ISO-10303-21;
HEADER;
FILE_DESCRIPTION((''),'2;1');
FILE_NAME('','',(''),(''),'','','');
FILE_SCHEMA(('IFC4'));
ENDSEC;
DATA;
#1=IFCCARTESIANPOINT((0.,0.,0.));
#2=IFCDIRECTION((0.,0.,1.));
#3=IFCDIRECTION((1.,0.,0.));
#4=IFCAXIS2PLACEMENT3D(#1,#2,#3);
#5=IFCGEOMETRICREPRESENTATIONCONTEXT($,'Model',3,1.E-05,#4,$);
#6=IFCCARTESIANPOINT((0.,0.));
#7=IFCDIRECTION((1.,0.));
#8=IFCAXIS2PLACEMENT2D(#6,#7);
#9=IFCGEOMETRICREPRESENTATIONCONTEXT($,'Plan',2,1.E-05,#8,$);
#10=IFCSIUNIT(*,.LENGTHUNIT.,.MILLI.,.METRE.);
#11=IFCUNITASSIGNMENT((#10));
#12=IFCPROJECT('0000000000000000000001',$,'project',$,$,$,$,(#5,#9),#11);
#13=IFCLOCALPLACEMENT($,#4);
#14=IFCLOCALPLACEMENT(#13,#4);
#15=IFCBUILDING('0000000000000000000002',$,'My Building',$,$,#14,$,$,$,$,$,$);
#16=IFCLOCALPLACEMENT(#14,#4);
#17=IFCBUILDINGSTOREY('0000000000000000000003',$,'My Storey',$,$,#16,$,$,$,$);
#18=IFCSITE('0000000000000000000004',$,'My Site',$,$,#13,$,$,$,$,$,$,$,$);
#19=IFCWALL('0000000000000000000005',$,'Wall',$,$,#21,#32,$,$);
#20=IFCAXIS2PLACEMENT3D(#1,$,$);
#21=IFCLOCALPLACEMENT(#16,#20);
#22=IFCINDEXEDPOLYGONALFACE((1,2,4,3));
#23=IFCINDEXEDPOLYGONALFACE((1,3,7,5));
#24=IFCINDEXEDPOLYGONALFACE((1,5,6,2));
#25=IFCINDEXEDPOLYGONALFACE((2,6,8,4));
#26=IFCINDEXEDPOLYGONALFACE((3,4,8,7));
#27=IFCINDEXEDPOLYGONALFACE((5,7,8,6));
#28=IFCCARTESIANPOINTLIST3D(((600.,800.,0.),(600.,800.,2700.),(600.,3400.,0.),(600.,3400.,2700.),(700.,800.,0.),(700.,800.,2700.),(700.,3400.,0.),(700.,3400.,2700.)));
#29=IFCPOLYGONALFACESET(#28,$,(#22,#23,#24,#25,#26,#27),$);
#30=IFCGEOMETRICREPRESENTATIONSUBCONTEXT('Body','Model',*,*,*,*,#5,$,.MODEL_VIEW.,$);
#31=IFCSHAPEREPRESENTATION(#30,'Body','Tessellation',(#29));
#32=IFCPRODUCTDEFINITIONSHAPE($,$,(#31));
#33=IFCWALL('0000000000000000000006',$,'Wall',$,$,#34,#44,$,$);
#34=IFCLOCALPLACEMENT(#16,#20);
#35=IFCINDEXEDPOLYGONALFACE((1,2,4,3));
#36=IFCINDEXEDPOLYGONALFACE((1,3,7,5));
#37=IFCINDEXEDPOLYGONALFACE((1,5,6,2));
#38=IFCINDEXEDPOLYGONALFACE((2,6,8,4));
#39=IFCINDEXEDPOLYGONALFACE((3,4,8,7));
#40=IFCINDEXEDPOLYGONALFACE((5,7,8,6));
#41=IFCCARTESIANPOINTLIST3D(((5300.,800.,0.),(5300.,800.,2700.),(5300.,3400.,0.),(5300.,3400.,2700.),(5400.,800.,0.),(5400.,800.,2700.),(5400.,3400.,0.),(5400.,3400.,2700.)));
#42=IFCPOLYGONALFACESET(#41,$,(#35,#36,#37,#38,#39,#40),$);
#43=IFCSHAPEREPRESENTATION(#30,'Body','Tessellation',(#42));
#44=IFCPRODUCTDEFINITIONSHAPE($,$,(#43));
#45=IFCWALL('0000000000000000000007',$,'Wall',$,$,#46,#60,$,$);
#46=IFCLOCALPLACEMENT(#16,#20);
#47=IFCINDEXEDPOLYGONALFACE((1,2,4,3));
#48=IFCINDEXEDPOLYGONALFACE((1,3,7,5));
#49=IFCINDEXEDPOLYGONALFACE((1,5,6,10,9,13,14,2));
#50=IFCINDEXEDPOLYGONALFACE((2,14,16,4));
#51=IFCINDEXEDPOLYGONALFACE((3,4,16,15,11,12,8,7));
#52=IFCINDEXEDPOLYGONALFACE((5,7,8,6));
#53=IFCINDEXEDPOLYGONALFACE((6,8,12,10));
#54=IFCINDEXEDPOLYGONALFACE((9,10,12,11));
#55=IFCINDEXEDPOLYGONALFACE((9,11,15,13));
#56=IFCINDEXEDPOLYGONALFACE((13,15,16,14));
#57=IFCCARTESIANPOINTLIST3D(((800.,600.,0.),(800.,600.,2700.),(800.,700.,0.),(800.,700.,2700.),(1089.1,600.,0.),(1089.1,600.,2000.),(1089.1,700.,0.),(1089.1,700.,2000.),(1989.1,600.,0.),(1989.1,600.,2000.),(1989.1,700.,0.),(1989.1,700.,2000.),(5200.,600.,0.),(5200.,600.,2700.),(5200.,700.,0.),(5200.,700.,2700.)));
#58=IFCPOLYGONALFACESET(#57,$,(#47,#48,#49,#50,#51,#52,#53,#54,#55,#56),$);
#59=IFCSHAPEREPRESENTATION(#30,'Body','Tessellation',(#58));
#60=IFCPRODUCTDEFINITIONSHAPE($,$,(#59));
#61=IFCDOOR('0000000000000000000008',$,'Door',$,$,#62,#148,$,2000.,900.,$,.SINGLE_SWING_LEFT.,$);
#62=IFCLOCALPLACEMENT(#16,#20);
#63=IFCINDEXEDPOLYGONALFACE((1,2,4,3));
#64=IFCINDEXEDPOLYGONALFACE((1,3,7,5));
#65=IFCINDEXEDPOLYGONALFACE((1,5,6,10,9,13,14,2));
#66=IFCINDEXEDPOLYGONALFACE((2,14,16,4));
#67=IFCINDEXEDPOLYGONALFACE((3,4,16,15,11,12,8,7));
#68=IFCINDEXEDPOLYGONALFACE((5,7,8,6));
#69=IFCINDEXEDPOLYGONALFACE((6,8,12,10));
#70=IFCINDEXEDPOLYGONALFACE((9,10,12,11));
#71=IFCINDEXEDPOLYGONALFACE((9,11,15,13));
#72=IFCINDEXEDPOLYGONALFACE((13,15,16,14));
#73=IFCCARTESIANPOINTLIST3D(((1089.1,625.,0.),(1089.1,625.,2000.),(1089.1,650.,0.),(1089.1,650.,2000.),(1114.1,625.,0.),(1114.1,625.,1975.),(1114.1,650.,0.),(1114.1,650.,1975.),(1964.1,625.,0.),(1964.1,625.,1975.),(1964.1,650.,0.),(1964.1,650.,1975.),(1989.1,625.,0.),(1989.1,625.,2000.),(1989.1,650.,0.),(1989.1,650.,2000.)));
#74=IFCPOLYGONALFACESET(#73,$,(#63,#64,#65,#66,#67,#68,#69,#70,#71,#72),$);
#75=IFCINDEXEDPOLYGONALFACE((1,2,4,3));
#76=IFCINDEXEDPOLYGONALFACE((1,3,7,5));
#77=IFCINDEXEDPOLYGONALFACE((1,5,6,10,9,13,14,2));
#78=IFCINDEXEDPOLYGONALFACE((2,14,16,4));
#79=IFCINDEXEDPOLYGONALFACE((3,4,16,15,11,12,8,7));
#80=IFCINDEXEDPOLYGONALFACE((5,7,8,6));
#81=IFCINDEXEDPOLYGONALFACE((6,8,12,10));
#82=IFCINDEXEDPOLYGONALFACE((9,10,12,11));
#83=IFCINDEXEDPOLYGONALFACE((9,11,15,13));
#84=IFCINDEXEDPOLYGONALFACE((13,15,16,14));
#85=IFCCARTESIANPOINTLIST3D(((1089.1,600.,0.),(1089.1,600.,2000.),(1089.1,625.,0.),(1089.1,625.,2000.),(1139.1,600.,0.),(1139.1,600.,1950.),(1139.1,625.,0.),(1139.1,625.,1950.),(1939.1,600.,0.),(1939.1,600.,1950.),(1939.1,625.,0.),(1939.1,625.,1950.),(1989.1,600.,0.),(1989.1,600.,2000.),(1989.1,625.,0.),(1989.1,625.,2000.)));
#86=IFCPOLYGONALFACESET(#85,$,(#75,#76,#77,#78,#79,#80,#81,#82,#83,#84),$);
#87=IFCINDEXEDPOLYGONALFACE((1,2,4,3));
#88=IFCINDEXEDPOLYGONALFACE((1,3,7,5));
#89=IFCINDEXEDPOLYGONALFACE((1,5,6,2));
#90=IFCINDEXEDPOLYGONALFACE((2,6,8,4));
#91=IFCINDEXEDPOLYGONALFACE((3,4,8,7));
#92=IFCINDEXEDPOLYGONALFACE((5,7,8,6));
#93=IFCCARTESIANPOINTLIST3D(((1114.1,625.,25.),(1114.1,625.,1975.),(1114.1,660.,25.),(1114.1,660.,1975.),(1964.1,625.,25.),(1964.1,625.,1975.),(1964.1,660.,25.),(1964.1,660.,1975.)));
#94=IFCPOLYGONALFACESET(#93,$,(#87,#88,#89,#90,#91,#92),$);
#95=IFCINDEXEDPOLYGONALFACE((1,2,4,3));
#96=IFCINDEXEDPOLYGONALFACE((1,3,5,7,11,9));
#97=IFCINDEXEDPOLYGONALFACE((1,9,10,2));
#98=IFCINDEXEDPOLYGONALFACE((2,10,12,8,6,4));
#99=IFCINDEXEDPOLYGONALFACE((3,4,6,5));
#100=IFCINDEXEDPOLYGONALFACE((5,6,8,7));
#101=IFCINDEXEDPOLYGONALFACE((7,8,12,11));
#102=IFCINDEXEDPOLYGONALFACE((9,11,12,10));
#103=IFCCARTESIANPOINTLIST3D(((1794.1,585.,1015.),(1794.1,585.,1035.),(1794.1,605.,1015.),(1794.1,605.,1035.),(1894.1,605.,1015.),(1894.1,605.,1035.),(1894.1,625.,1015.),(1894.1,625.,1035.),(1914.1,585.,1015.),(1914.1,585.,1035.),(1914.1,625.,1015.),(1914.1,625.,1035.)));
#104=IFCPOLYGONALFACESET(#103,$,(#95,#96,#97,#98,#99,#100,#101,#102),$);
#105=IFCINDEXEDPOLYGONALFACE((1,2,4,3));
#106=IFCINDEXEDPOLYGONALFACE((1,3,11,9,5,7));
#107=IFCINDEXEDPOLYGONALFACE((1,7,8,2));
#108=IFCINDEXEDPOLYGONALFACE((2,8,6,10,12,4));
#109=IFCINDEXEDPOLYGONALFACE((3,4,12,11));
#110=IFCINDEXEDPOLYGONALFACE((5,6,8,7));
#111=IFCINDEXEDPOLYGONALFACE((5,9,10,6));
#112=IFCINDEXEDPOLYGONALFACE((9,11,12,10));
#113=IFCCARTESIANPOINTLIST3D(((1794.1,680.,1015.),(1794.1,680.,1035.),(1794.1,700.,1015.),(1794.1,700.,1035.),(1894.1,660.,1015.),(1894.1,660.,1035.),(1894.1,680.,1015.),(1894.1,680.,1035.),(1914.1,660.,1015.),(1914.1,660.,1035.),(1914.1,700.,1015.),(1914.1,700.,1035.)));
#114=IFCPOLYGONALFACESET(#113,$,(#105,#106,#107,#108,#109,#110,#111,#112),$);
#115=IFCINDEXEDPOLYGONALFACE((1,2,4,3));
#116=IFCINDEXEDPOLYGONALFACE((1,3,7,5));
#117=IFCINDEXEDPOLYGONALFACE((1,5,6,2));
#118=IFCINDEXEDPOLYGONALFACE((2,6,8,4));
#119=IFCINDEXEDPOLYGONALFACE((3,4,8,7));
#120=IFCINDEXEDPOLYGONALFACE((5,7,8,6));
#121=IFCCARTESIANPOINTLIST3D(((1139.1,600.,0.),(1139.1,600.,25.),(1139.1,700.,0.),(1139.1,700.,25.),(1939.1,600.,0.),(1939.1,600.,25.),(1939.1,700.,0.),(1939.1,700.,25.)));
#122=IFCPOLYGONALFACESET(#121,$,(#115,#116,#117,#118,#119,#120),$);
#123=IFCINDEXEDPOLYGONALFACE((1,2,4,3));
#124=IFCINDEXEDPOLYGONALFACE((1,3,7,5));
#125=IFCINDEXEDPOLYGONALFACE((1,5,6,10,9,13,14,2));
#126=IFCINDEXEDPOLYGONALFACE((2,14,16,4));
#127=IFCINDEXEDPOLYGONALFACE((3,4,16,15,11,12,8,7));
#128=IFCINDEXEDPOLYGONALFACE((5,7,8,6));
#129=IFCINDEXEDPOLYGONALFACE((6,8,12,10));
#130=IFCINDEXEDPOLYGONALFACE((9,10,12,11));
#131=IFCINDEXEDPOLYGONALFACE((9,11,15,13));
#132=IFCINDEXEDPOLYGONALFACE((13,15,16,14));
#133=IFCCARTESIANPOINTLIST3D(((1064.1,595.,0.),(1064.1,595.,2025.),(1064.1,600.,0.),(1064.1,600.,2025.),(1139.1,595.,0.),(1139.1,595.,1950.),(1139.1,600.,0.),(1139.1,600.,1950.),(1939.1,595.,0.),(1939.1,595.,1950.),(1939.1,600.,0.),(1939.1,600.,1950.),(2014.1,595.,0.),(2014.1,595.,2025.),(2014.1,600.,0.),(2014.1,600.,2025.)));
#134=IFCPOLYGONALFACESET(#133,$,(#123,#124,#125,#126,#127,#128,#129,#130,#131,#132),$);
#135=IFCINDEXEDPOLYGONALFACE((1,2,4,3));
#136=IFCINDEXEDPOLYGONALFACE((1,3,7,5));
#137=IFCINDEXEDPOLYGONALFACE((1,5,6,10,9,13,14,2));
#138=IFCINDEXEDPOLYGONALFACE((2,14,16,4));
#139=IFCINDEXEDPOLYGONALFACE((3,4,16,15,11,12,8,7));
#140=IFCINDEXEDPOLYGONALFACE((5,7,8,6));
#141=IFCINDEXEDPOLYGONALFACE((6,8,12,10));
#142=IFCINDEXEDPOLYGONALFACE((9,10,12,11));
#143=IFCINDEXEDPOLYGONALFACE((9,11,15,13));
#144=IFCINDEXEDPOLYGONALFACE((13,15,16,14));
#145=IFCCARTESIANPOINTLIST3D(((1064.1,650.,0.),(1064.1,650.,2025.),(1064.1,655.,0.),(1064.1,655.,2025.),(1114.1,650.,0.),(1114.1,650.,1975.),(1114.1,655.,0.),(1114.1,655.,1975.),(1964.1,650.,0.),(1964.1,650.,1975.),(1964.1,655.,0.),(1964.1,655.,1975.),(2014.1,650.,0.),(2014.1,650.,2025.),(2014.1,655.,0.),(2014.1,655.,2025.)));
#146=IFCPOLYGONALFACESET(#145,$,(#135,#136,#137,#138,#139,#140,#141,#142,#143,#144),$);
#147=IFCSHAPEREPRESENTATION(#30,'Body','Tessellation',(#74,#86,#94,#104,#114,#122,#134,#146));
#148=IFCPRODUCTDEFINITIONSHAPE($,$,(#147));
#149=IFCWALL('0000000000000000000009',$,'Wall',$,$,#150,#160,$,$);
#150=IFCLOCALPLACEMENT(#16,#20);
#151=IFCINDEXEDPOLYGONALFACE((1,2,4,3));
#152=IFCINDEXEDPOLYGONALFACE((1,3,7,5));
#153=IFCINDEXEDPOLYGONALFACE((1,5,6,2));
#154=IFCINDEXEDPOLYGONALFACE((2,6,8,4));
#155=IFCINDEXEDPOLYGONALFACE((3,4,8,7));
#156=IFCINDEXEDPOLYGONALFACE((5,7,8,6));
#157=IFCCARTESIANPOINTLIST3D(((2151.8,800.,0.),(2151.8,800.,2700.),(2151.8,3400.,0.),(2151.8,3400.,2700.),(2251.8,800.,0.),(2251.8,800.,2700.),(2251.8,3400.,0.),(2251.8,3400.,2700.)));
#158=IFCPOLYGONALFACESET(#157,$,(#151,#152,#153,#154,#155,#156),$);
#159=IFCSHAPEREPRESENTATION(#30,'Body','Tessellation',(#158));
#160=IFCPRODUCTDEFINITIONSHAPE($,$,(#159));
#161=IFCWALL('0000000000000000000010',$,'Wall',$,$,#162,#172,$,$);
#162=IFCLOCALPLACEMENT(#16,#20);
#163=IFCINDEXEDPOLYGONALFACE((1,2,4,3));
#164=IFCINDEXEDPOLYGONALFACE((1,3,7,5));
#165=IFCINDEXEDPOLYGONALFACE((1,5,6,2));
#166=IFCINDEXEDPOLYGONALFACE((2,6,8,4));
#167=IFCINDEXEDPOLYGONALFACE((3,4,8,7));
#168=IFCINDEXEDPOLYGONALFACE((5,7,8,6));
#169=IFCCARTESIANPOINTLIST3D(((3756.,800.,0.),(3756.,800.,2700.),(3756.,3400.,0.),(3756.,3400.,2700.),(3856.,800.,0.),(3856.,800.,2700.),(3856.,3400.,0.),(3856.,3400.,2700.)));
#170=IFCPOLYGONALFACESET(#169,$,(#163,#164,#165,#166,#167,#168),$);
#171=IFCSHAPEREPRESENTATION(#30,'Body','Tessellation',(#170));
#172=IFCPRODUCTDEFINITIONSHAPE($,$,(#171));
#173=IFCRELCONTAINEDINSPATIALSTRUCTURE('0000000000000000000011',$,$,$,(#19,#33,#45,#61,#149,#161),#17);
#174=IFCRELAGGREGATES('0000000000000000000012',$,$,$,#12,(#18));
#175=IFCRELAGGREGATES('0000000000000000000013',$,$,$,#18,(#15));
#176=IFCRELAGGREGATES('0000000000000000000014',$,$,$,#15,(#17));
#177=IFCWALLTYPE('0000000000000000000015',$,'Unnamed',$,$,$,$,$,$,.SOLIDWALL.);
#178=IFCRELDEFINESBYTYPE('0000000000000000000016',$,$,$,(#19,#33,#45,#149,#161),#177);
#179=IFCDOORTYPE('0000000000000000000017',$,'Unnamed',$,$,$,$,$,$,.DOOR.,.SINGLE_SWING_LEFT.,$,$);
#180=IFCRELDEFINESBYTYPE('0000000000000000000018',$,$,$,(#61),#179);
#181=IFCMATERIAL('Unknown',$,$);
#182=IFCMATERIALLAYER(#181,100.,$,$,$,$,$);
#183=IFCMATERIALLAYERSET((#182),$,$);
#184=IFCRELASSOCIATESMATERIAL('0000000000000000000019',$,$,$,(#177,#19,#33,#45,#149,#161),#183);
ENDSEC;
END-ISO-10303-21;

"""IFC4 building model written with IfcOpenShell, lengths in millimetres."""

from ifc_helpers import new_model, entity, si_unit, frame, origin_with_axes, origin_2d_with_axis, place, context, subcontext, project, spatial, line, indexed_curve, outline, extrude, shape, source, transform, mapped, material, layer, layer_set, layer_usage, type_object, type_shapes, element, fill, save


model = new_model("IFC4")

# Units and contexts
model_context = context("Model", 3, precision=1e-05, world=origin_with_axes())
plan_context = context("Plan", 2, precision=1e-05, world=origin_2d_with_axis())
body_context_1 = subcontext(model_context, "Body", "Model", "MODEL_VIEW")
body_context_2 = subcontext(plan_context, "Body", "Plan", "PLAN_VIEW")
ifc_project = project(units=[si_unit("LENGTHUNIT", "METRE", prefix="MILLI")], contexts=[model_context, plan_context])

# Site, building, storey
site_placement = place(None, origin_with_axes())
site = spatial("IfcSite", under=ifc_project, at=site_placement, Name="My Site")
building_placement = place(site_placement, origin_with_axes())
building = spatial("IfcBuilding", under=site, at=building_placement, Name="My Building")
storey_placement = place(building_placement, origin_with_axes())
storey = spatial("IfcBuildingStorey", under=building, at=storey_placement, Name="My Storey")

# Shared definitions
ifc_material = material(Name="Unknown")

# Walls
ifc_layer_1 = layer(ifc_material, 100.0)
ifc_layer_set_1 = layer_set([ifc_layer_1])
ifc_layer_usage_1 = layer_usage(ifc_layer_set_1, "AXIS2", "POSITIVE", 0.0)
wall_type = type_object("IfcWallType", Name="Unnamed", PredefinedType="SOLIDWALL", material=ifc_layer_set_1)
wall_1_placement = place(storey_placement, frame((600.0, 3400.0, 0.0), z_axis=(0.0, 0.0, 1.0), x_axis=(0.0, -1.0, 0.0)))
element("IfcWall", 1, at=wall_1_placement, inside=storey, type_object=wall_type, material=ifc_layer_usage_1, Name="Wall", context=body_context_1, shape_type="SweptSolid", body=[
    extrude(outline(indexed_curve([(0.0, 0.0), (0.0, 100.0), (2600.0, 100.0), (2600.0, 0.0)], segments=[line(1, 2, 3, 4, 1)])), origin_with_axes(), (0.0, 0.0, 1.0), 2700.0),
])
ifc_layer_usage_2 = layer_usage(ifc_layer_set_1, "AXIS2", "POSITIVE", 0.0)
wall_2_placement = place(storey_placement, frame((5300.0, 3400.0, 0.0), z_axis=(0.0, 0.0, 1.0), x_axis=(0.0, -1.0, 0.0)))
element("IfcWall", 2, at=wall_2_placement, inside=storey, type_object=wall_type, material=ifc_layer_usage_2, Name="Wall", context=body_context_1, shape_type="SweptSolid", body=[
    extrude(outline(indexed_curve([(0.0, 0.0), (0.0, 100.0), (2600.0, 100.0), (2600.0, 0.0)], segments=[line(1, 2, 3, 4, 1)])), origin_with_axes(), (0.0, 0.0, 1.0), 2700.0),
])

# Wall, opening, door
ifc_layer_usage_3 = layer_usage(ifc_layer_set_1, "AXIS2", "POSITIVE", 0.0)
wall_3_placement = place(storey_placement, frame((800.0, 600.0, 0.0), z_axis=(0.0, 0.0, 1.0), x_axis=(1.0, 0.0, 0.0)))
wall_3 = element("IfcWall", 3, at=wall_3_placement, inside=storey, type_object=wall_type, material=ifc_layer_usage_3, Name="Wall", context=body_context_1, shape_type="SweptSolid", body=[
    extrude(outline(indexed_curve([(0.0, 0.0), (0.0, 100.0), (4400.0, 100.0), (4400.0, 0.0)], segments=[line(1, 2, 3, 4, 1)])), origin_with_axes(), (0.0, 0.0, 1.0), 2700.0),
])
shared_shape_1 = source(origin_with_axes(), body_context_1, "Body", "SweptSolid", [
    extrude(outline(indexed_curve([(0.0, 0.0), (900.0, 0.0), (900.0, 2000.0), (0.0, 2000.0)], segments=[line(1, 2, 3, 4, 1)])), frame((0.0, -600.0, 0.0), z_axis=(0.0, -1.0, 0.0), x_axis=(1.0, 0.0, 0.0)), (0.0, 0.0, -1.0), 1200.0),
])
opening_1_placement = place(wall_3_placement, frame((289.1, 0.0, 0.0), z_axis=(0.0, 0.0, 1.0), x_axis=(1.0, 0.0, 0.0)))
opening_1 = element("IfcOpeningElement", 4, at=opening_1_placement, cuts=wall_3, PredefinedType="OPENING", context=body_context_1, shape_type="MappedRepresentation", body=[
    mapped(shared_shape_1, transform((0.0, 0.0, 0.0), x_axis=(1.0, 0.0, 0.0), y_axis=(0.0, 1.0, 0.0), z_axis=(0.0, 0.0, 1.0), scale=1.0)),
])
door_type = type_object("IfcDoorType", Name="Unnamed", OperationType="SINGLE_SWING_LEFT", PredefinedType="DOOR")
shared_shape_2 = source(origin_with_axes(), body_context_1, "Body", "SweptSolid", [
    extrude(outline(indexed_curve([(0.0, 0.0), (0.0, 2000.0), (900.0, 2000.0), (900.0, 0.0), (875.0, 0.0), (875.0, 1975.0), (25.0, 1975.0), (25.0, 0.0)], segments=[line(1, 2, 3, 4, 5, 6, 7, 8, 1)])), frame((0.0, 25.0, 0.0), z_axis=(0.0, -1.0, 0.0), x_axis=(1.0, 0.0, 0.0)), (0.0, 0.0, -1.0), 25.0),
    extrude(outline(indexed_curve([(0.0, 0.0), (0.0, 2000.0), (900.0, 2000.0), (900.0, 0.0), (850.0, 0.0), (850.0, 1950.0), (50.0, 1950.0), (50.0, 0.0)], segments=[line(1, 2, 3, 4, 5, 6, 7, 8, 1)])), frame((0.0, 0.0, 0.0), z_axis=(0.0, -1.0, 0.0), x_axis=(1.0, 0.0, 0.0)), (0.0, 0.0, -1.0), 25.0),
    extrude(outline(indexed_curve([(0.0, 0.0), (850.0, 0.0), (850.0, 35.0), (0.0, 35.0)], segments=[line(1, 2, 3, 4, 1)])), frame((25.0, 25.0, 25.0), z_axis=(0.0, 0.0, 1.0), x_axis=(1.0, 0.0, 0.0)), (0.0, 0.0, 1.0), 1950.0),
    extrude(outline(indexed_curve([(0.0, 0.0), (0.0, -40.0), (-120.0, -40.0), (-120.0, -20.0), (-20.0, -20.0), (-20.0, 0.0)], segments=[line(1, 2, 3, 4, 5, 6, 1)])), frame((825.0, 25.0, 1015.0), z_axis=(0.0, 0.0, 1.0), x_axis=(1.0, 0.0, 0.0)), (0.0, 0.0, 1.0), 20.0),
    extrude(outline(indexed_curve([(0.0, 0.0), (0.0, 40.0), (-120.0, 40.0), (-120.0, 20.0), (-20.0, 20.0), (-20.0, 0.0)], segments=[line(1, 2, 3, 4, 5, 6, 1)])), frame((825.0, 60.0, 1015.0), z_axis=(0.0, 0.0, 1.0), x_axis=(1.0, 0.0, 0.0)), (0.0, 0.0, 1.0), 20.0),
    extrude(outline(indexed_curve([(0.0, 0.0), (800.0, 0.0), (800.0, 100.0), (0.0, 100.0)], segments=[line(1, 2, 3, 4, 1)])), frame((50.0, 0.0, 0.0), z_axis=(0.0, 0.0, 1.0), x_axis=(1.0, 0.0, 0.0)), (0.0, 0.0, 1.0), 25.0),
    extrude(outline(indexed_curve([(0.0, 0.0), (0.0, 2025.0), (950.0, 2025.0), (950.0, 0.0), (875.0, 0.0), (875.0, 1950.0), (75.0, 1950.0), (75.0, 0.0)], segments=[line(1, 2, 3, 4, 5, 6, 7, 8, 1)])), frame((-25.0, -5.0, 0.0), z_axis=(0.0, -1.0, 0.0), x_axis=(1.0, 0.0, 0.0)), (0.0, 0.0, -1.0), 5.0),
    extrude(outline(indexed_curve([(0.0, 0.0), (0.0, 2025.0), (950.0, 2025.0), (950.0, 0.0), (900.0, 0.0), (900.0, 1975.0), (50.0, 1975.0), (50.0, 0.0)], segments=[line(1, 2, 3, 4, 5, 6, 7, 8, 1)])), frame((-25.0, 50.0, 0.0), z_axis=(0.0, -1.0, 0.0), x_axis=(1.0, 0.0, 0.0)), (0.0, 0.0, -1.0), 5.0),
])
shared_shape_3 = source(origin_with_axes(), body_context_2, "Body", "Curve2D", [
    entity("IfcIndexedPolyCurve", entity("IfcCartesianPointList2D", [[0.0, 0.0], [0.0, 50.0], [25.0, 50.0], [25.0, 25.0], [50.0, 25.0], [50.0, 0.0]]), [entity("IfcLineIndex", [1, 2, 3, 4, 5, 6, 1])]),
    entity("IfcIndexedPolyCurve", entity("IfcCartesianPointList2D", [[900.0, 0.0], [900.0, 50.0], [875.0, 50.0], [875.0, 25.0], [850.0, 25.0], [850.0, 0.0]]), [entity("IfcLineIndex", [1, 2, 3, 4, 5, 6, 1])]),
    entity("IfcTrimmedCurve", entity("IfcEllipse", entity("IfcAxis2Placement2D", entity("IfcCartesianPoint", [60.0, 50.0]), entity("IfcDirection", [1.0, 0.0])), 815.0, 850.0), [entity("IfcCartesianPoint", [875.0, 50.0])], [entity("IfcCartesianPoint", [60.0, 900.0])], True, "CARTESIAN"),
    entity("IfcIndexedPolyCurve", entity("IfcCartesianPointList2D", [[25.0, 50.0], [60.0, 50.0], [60.0, 900.0], [25.0, 900.0]]), [entity("IfcLineIndex", [1, 2, 3, 4, 1])]),
])
type_shapes(door_type, [shared_shape_2, shared_shape_3])
door_placement = place(opening_1_placement, origin_with_axes())
door = element("IfcDoor", 5, at=door_placement, inside=storey, type_object=door_type, Name="Door", OperationType="SINGLE_SWING_LEFT", OverallHeight=2000.0, OverallWidth=900.0, shapes=[
    shape(body_context_1, "Body", "MappedRepresentation", [mapped(shared_shape_2, transform((0.0, 0.0, 0.0), x_axis=(1.0, 0.0, 0.0), y_axis=(0.0, 1.0, 0.0), z_axis=(0.0, 0.0, 1.0), scale=1.0))]),
    shape(body_context_2, "Body", "MappedRepresentation", [mapped(shared_shape_3, transform((0.0, 0.0, 0.0), x_axis=(1.0, 0.0, 0.0), y_axis=(0.0, 1.0, 0.0), z_axis=(0.0, 0.0, 1.0), scale=1.0))]),
])
fill(opening_1, door)

# Walls
ifc_layer_usage_4 = layer_usage(ifc_layer_set_1, "AXIS2", "POSITIVE", 0.0)
wall_4_placement = place(storey_placement, frame((2151.8, 3400.0, 0.0), z_axis=(0.0, 0.0, 1.0), x_axis=(0.0, -1.0, 0.0)))
element("IfcWall", 6, at=wall_4_placement, inside=storey, type_object=wall_type, material=ifc_layer_usage_4, Name="Wall", context=body_context_1, shape_type="SweptSolid", body=[
    extrude(outline(indexed_curve([(0.0, 0.0), (0.0, 100.0), (2600.0, 100.0), (2600.0, 0.0)], segments=[line(1, 2, 3, 4, 1)])), origin_with_axes(), (0.0, 0.0, 1.0), 2700.0),
])
ifc_layer_usage_5 = layer_usage(ifc_layer_set_1, "AXIS2", "POSITIVE", 0.0)
wall_5_placement = place(storey_placement, frame((3756.0, 3400.0, 0.0), z_axis=(0.0, 0.0, 1.0), x_axis=(0.0, -1.0, 0.0)))
element("IfcWall", 7, at=wall_5_placement, inside=storey, type_object=wall_type, material=ifc_layer_usage_5, Name="Wall", context=body_context_1, shape_type="SweptSolid", body=[
    extrude(outline(indexed_curve([(0.0, 0.0), (0.0, 100.0), (2600.0, 100.0), (2600.0, 0.0)], segments=[line(1, 2, 3, 4, 1)])), origin_with_axes(), (0.0, 0.0, 1.0), 2700.0),
])

save(model, "model.ifc")
